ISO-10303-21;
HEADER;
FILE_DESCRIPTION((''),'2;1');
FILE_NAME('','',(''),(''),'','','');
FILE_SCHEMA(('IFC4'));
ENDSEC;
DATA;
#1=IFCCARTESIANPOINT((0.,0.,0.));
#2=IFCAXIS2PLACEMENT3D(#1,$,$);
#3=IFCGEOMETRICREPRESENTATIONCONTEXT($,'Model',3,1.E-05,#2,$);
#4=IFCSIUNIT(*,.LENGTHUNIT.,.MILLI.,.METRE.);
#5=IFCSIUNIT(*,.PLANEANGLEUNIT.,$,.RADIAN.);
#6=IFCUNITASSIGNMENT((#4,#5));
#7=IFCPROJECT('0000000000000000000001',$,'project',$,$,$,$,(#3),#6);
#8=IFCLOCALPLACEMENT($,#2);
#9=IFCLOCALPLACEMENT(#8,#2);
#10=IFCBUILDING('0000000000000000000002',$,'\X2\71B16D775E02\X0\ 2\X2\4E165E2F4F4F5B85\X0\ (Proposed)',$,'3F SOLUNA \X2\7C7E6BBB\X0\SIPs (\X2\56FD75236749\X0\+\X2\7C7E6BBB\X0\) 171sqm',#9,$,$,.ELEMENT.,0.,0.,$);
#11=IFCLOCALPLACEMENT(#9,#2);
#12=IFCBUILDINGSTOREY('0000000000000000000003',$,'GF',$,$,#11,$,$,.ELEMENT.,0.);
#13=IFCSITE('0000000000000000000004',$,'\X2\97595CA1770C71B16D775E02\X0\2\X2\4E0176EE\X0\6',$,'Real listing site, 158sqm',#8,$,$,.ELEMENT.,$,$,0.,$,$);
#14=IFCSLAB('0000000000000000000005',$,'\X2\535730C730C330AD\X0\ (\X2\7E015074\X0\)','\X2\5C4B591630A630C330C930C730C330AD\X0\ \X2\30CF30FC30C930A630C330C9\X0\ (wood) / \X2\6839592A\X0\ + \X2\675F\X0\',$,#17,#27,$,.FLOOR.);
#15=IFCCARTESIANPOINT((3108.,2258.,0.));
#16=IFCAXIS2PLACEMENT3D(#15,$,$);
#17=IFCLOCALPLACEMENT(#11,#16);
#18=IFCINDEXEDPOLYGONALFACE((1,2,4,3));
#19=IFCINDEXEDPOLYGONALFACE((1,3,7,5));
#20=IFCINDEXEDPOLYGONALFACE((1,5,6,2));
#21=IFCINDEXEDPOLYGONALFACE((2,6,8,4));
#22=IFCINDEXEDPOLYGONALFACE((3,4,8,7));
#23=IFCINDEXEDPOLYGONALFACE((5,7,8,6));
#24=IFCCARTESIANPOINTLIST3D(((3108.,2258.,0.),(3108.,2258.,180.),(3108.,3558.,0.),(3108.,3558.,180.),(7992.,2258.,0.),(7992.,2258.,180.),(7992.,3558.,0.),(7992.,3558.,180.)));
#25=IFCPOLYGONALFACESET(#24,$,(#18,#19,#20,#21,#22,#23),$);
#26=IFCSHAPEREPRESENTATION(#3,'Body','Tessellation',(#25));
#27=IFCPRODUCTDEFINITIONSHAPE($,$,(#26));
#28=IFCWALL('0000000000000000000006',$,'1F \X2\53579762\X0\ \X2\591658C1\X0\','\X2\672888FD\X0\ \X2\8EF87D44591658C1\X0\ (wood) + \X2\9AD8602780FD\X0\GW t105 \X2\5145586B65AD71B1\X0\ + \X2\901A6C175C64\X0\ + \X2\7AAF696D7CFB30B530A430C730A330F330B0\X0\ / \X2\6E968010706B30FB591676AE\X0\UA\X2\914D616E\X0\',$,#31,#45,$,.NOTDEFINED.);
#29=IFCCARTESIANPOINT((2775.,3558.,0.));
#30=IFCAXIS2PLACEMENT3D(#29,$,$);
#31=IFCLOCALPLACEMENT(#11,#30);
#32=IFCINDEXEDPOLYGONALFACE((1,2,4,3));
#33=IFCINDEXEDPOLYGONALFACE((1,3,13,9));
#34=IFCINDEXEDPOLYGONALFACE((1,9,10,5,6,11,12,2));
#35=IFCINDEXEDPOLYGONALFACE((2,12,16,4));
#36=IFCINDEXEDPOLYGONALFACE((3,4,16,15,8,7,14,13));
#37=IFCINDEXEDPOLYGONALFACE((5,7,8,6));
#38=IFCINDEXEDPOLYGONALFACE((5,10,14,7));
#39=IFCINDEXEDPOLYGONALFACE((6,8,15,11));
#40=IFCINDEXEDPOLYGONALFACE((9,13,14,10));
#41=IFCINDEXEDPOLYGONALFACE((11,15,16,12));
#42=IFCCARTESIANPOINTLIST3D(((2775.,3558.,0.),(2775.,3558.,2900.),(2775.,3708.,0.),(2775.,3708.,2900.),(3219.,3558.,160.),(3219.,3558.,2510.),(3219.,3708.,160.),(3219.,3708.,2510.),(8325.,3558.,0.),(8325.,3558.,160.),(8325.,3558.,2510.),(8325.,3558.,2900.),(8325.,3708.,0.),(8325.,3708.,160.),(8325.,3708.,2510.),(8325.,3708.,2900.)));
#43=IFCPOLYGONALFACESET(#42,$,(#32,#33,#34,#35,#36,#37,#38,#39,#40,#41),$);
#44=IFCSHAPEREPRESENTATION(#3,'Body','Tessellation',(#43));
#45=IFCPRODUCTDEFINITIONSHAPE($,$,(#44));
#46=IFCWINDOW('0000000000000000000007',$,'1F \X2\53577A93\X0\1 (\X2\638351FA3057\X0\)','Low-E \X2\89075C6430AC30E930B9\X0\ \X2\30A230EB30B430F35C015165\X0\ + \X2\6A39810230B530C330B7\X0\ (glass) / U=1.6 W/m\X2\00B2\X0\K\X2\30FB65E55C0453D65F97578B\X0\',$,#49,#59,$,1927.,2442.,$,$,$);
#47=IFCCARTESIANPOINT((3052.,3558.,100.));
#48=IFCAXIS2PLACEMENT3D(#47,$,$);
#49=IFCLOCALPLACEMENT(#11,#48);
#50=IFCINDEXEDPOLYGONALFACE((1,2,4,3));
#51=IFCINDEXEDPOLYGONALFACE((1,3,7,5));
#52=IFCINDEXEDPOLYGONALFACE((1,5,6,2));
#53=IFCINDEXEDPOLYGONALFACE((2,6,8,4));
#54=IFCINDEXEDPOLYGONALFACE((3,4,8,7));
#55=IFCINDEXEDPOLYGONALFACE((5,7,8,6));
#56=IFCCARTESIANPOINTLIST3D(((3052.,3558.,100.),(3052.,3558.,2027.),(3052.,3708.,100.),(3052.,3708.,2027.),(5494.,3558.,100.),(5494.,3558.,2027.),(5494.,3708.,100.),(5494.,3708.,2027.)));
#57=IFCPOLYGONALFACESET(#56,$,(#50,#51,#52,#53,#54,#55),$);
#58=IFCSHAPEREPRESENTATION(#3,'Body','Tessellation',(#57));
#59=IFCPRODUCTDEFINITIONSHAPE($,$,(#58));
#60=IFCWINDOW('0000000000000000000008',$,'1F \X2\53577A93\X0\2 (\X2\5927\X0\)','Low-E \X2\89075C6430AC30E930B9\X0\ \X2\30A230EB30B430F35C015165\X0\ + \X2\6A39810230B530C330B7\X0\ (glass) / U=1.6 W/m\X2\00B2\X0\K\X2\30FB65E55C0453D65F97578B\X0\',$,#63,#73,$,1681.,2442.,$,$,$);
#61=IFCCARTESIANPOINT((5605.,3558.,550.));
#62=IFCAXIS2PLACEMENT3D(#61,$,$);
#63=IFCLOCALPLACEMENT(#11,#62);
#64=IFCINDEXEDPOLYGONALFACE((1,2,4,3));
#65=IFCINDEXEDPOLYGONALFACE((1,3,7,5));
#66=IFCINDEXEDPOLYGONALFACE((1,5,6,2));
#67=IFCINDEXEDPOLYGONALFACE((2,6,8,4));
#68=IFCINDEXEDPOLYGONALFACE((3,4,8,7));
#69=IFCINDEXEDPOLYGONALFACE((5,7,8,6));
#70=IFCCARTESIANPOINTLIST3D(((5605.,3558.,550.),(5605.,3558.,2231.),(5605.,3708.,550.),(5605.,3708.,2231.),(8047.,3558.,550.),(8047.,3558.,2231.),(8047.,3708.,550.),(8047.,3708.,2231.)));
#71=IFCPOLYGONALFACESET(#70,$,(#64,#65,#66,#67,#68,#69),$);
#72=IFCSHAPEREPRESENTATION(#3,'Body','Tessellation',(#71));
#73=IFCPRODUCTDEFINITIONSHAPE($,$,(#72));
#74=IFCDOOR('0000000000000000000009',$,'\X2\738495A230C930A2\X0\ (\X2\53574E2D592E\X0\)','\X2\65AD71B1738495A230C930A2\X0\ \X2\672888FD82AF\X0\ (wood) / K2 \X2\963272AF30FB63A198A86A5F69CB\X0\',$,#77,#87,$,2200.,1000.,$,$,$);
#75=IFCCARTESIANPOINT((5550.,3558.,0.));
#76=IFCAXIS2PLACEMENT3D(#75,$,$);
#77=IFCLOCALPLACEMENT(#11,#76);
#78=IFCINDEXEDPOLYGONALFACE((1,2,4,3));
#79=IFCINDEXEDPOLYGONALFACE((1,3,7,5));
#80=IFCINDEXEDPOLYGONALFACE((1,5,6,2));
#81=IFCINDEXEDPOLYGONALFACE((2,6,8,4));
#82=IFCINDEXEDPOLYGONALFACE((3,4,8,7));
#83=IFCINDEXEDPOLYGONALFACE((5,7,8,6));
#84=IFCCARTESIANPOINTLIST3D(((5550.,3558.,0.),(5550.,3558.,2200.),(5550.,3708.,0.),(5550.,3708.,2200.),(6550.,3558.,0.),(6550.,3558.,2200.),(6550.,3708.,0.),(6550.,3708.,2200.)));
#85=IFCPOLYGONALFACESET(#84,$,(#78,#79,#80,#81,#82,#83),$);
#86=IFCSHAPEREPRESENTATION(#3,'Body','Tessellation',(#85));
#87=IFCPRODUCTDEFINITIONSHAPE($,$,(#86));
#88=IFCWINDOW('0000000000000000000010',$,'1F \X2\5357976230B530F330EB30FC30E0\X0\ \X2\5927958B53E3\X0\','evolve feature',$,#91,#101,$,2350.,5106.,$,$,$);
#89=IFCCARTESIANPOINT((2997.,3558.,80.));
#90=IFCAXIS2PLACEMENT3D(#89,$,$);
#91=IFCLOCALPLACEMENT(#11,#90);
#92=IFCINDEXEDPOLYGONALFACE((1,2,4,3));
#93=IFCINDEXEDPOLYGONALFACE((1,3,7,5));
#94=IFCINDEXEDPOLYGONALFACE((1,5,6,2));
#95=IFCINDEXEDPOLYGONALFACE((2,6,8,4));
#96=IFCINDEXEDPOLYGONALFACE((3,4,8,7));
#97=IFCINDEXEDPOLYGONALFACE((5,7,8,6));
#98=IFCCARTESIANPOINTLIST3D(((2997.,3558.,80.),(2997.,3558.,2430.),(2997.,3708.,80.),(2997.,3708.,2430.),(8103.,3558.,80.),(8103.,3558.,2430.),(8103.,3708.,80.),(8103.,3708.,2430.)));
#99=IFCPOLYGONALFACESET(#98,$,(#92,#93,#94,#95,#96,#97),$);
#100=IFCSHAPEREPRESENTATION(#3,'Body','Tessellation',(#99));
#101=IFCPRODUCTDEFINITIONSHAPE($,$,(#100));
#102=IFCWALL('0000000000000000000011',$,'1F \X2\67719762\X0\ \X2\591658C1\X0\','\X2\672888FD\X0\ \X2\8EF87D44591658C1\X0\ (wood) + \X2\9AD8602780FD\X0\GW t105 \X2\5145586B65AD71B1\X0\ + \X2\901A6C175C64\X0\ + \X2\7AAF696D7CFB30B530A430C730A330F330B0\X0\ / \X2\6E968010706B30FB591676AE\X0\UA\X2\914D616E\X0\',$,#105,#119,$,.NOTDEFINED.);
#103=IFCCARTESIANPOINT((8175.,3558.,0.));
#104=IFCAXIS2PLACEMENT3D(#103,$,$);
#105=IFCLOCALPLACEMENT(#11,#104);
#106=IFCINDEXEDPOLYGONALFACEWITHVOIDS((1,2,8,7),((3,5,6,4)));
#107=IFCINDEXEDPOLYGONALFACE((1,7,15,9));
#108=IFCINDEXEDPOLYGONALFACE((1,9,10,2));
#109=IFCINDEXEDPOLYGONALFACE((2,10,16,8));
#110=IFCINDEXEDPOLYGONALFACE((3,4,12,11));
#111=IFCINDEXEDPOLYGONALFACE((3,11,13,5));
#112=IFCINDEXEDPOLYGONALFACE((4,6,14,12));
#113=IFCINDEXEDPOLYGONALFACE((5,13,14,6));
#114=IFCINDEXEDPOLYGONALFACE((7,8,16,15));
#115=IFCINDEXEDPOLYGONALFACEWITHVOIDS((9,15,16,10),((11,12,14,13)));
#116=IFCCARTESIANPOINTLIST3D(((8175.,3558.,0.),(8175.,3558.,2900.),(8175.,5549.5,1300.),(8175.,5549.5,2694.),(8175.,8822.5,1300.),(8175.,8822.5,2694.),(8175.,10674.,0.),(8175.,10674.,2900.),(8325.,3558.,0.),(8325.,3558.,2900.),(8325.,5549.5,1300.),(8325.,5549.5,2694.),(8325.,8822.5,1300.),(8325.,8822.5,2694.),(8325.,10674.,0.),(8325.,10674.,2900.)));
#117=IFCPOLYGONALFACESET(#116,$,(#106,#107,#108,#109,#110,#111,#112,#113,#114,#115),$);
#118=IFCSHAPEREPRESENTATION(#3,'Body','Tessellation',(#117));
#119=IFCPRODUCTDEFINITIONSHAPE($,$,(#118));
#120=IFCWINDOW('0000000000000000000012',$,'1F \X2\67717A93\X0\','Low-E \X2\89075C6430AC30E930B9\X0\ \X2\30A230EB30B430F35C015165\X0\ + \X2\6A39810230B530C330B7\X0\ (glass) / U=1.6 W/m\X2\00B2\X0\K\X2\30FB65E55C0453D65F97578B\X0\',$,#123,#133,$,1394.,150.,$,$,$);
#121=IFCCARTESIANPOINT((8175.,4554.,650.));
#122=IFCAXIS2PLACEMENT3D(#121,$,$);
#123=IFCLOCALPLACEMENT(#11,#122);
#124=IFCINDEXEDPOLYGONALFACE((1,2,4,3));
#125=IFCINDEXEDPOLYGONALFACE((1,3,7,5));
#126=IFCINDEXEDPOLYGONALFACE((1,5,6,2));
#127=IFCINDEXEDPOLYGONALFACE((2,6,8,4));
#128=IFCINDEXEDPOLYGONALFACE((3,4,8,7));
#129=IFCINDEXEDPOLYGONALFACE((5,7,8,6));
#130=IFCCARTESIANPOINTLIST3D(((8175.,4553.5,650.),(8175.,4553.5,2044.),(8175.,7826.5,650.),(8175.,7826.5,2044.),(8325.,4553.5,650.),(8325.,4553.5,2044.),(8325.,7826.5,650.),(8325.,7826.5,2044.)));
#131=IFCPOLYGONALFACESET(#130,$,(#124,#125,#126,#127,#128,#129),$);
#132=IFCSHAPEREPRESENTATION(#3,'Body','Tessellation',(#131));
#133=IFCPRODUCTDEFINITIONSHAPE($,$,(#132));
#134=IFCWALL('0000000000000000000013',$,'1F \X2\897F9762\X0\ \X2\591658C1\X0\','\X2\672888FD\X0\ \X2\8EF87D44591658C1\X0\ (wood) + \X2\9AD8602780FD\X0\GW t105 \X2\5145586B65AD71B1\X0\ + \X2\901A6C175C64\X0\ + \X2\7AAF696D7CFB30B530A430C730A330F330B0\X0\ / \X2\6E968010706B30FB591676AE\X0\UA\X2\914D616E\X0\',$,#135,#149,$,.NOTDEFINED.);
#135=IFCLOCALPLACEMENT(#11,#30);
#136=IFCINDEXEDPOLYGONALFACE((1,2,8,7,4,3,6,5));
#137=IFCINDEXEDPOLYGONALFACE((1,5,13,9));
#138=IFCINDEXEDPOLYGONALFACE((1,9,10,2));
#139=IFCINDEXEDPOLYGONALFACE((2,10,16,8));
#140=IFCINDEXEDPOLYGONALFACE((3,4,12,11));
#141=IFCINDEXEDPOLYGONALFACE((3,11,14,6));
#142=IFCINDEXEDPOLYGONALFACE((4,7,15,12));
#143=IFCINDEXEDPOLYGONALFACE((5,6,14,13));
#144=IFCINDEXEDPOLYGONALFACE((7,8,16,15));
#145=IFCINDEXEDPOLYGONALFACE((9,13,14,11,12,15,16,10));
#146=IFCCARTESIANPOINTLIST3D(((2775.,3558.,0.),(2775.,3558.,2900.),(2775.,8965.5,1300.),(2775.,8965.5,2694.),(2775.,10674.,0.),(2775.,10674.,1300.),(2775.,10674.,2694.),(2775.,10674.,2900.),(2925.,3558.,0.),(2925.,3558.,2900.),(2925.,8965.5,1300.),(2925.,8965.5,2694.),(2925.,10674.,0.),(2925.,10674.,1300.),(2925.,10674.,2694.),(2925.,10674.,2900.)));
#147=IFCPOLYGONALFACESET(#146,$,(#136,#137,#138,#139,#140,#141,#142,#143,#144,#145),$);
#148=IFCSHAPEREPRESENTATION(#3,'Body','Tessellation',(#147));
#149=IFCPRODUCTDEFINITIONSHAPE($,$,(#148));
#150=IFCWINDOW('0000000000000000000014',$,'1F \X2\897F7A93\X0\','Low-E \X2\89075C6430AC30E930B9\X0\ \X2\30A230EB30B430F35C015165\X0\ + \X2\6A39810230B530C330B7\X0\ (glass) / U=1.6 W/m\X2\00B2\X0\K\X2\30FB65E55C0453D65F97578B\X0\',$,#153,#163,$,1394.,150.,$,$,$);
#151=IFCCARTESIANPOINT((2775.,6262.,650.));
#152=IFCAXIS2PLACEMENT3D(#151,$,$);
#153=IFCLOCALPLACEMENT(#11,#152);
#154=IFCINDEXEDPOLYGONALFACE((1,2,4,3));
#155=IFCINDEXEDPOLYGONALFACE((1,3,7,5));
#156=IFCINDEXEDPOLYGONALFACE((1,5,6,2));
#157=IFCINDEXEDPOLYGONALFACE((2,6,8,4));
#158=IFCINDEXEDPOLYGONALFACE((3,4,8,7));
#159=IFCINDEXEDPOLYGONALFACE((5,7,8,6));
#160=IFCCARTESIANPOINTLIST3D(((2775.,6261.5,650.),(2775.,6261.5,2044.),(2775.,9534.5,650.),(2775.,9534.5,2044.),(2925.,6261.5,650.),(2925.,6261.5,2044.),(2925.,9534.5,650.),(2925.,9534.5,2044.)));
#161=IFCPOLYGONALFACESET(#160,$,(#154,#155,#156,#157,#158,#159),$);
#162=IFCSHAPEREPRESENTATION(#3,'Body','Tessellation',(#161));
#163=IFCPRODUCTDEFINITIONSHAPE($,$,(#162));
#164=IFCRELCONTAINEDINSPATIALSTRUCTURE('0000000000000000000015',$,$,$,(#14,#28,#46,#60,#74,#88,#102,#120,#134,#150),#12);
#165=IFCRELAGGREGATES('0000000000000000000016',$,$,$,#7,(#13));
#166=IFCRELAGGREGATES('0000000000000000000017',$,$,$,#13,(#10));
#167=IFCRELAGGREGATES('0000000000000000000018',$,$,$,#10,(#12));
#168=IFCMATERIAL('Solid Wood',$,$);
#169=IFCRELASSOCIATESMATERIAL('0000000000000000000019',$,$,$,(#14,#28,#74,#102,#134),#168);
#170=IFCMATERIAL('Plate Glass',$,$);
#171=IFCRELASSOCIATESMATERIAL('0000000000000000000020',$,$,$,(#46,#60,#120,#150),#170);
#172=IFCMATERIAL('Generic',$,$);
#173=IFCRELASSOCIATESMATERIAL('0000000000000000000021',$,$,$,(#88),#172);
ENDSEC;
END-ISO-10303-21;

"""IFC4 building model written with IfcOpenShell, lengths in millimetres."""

from ifc_helpers import new_model, si_unit, frame, frame_2d, origin, place, context, project, spatial, rectangle, extrude, material, element, fill, save


model = new_model("IFC4")

# Units and contexts
model_context = context("Model", 3, precision=1e-05, world=origin())
ifc_project = project(units=[si_unit("LENGTHUNIT", "METRE", prefix="MILLI"), si_unit("PLANEANGLEUNIT", "RADIAN")], contexts=[model_context])

# Site, building, storey
site_placement = place(None, origin())
site = spatial("IfcSite", under=ifc_project, at=site_placement, Name="静岡県熱海市2丁目6", ObjectType="Real listing site, 158sqm", CompositionType="ELEMENT", RefElevation=0.0)
building_placement = place(site_placement, origin())
building = spatial("IfcBuilding", under=site, at=building_placement, Name="熱海市 2世帯住宅 (Proposed)", ObjectType="3F SOLUNA 籾殻SIPs (国産杉+籾殻) 171sqm", CompositionType="ELEMENT", ElevationOfRefHeight=0.0, ElevationOfTerrain=0.0)
storey_placement = place(building_placement, origin())
storey = spatial("IfcBuildingStorey", under=building, at=storey_placement, Name="GF", CompositionType="ELEMENT", Elevation=0.0)

# Slab
ifc_material_1 = material(Name="Solid Wood")
slab_1_placement = place(storey_placement, frame((3108.0, 2258.0, 0.0)))
element("IfcSlab", 1, at=slab_1_placement, inside=storey, material=ifc_material_1, Name="南デッキ (縁側)", Description="屋外ウッドデッキ ハードウッド (wood) / 根太 + 束", PredefinedType="FLOOR", context=model_context, shape_type="SweptSolid", body=[
    extrude(rectangle(XDim=4884.0, YDim=1300.0, at=frame_2d((2442.0, 650.0))), frame((3108.0, 2258.0, 0.0)), (0.0, 0.0, 1.0), 180.0),
])

# Wall, openings, windows, door
wall_1_placement = place(storey_placement, frame((2775.0, 3558.0, 0.0)))
wall_1 = element("IfcWall", 2, at=wall_1_placement, inside=storey, material=ifc_material_1, Name="1F 南面 外壁", Description="木製 軸組外壁 (wood) + 高性能GW t105 充填断熱 + 通気層 + 窯業系サイディング / 準耐火・外皮UA配慮", PredefinedType="NOTDEFINED", context=model_context, shape_type="SweptSolid", body=[
    extrude(rectangle(XDim=5550.0, YDim=150.0, at=frame_2d((2775.0, 75.0))), frame((2775.0, 3558.0, 0.0)), (0.0, 0.0, 1.0), 2900.0),
])
opening_1_placement = place(storey_placement, frame((3052.0, 3558.0, 100.0)))
opening_1 = element("IfcOpeningElement", 3, at=opening_1_placement, cuts=wall_1, PredefinedType="NOTDEFINED", context=model_context, shape_type="SweptSolid", body=[
    extrude(rectangle(XDim=2442.0, YDim=150.0, at=frame_2d((1221.0, 75.0))), frame((3052.0, 3558.0, 100.0)), (0.0, 0.0, 1.0), 1927.0),
])
opening_2_placement = place(storey_placement, frame((5605.0, 3558.0, 550.0)))
opening_2 = element("IfcOpeningElement", 4, at=opening_2_placement, cuts=wall_1, PredefinedType="NOTDEFINED", context=model_context, shape_type="SweptSolid", body=[
    extrude(rectangle(XDim=2442.0, YDim=150.0, at=frame_2d((1221.0, 75.0))), frame((5605.0, 3558.0, 550.0)), (0.0, 0.0, 1.0), 1681.0),
])
opening_3_placement = place(storey_placement, frame((5550.0, 3558.0, 0.0)))
opening_3 = element("IfcOpeningElement", 5, at=opening_3_placement, cuts=wall_1, PredefinedType="NOTDEFINED", context=model_context, shape_type="SweptSolid", body=[
    extrude(rectangle(XDim=1000.0, YDim=150.0, at=frame_2d((500.0, 75.0))), frame((5550.0, 3558.0, 0.0)), (0.0, 0.0, 1.0), 2200.0),
])
opening_4_placement = place(storey_placement, frame((2997.0, 3558.0, 80.0)))
opening_4 = element("IfcOpeningElement", 6, at=opening_4_placement, cuts=wall_1, PredefinedType="NOTDEFINED", context=model_context, shape_type="SweptSolid", body=[
    extrude(rectangle(XDim=5106.0, YDim=150.0, at=frame_2d((2553.0, 75.0))), frame((2997.0, 3558.0, 80.0)), (0.0, 0.0, 1.0), 2350.0),
])
ifc_material_2 = material(Name="Plate Glass")
window_1_placement = place(storey_placement, frame((3052.0, 3558.0, 100.0)))
window_1 = element("IfcWindow", 7, at=window_1_placement, inside=storey, material=ifc_material_2, Name="1F 南窓1 (掃出し)", Description="Low-E 複層ガラス アルゴン封入 + 樹脂サッシ (glass) / U=1.6 W/m²K・日射取得型", OverallHeight=1927.0, OverallWidth=2442.0, context=model_context, shape_type="SweptSolid", body=[
    extrude(rectangle(XDim=2442.0, YDim=150.0, at=frame_2d((1221.0, 75.0))), frame((3052.0, 3558.0, 100.0)), (0.0, 0.0, 1.0), 1927.0),
])
fill(opening_1, window_1)
window_2_placement = place(storey_placement, frame((5605.0, 3558.0, 550.0)))
window_2 = element("IfcWindow", 8, at=window_2_placement, inside=storey, material=ifc_material_2, Name="1F 南窓2 (大)", Description="Low-E 複層ガラス アルゴン封入 + 樹脂サッシ (glass) / U=1.6 W/m²K・日射取得型", OverallHeight=1681.0, OverallWidth=2442.0, context=model_context, shape_type="SweptSolid", body=[
    extrude(rectangle(XDim=2442.0, YDim=150.0, at=frame_2d((1221.0, 75.0))), frame((5605.0, 3558.0, 550.0)), (0.0, 0.0, 1.0), 1681.0),
])
fill(opening_2, window_2)
door_placement = place(storey_placement, frame((5550.0, 3558.0, 0.0)))
door = element("IfcDoor", 9, at=door_placement, inside=storey, material=ifc_material_1, Name="玄関ドア (南中央)", Description="断熱玄関ドア 木製芯 (wood) / K2 防犯・採風機構", OverallHeight=2200.0, OverallWidth=1000.0, context=model_context, shape_type="SweptSolid", body=[
    extrude(rectangle(XDim=1000.0, YDim=150.0, at=frame_2d((500.0, 75.0))), frame((5550.0, 3558.0, 0.0)), (0.0, 0.0, 1.0), 2200.0),
])
fill(opening_3, door)
ifc_material_3 = material(Name="Generic")
window_3_placement = place(storey_placement, frame((2997.0, 3558.0, 80.0)))
window_3 = element("IfcWindow", 10, at=window_3_placement, inside=storey, material=ifc_material_3, Name="1F 南面サンルーム 大開口", Description="evolve feature", OverallHeight=2350.0, OverallWidth=5106.0, context=model_context, shape_type="SweptSolid", body=[
    extrude(rectangle(XDim=5106.0, YDim=150.0, at=frame_2d((2553.0, 75.0))), frame((2997.0, 3558.0, 80.0)), (0.0, 0.0, 1.0), 2350.0),
])
fill(opening_4, window_3)

# Walls, openings, windows
wall_2_placement = place(storey_placement, frame((8175.0, 3558.0, 0.0)))
wall_2 = element("IfcWall", 11, at=wall_2_placement, inside=storey, material=ifc_material_1, Name="1F 東面 外壁", Description="木製 軸組外壁 (wood) + 高性能GW t105 充填断熱 + 通気層 + 窯業系サイディング / 準耐火・外皮UA配慮", PredefinedType="NOTDEFINED", context=model_context, shape_type="SweptSolid", body=[
    extrude(rectangle(XDim=150.0, YDim=7116.0, at=frame_2d((75.0, 3558.0))), frame((8175.0, 3558.0, 0.0)), (0.0, 0.0, 1.0), 2900.0),
])
opening_5_placement = place(storey_placement, frame((8175.0, 4554.0, 650.0)))
opening_5 = element("IfcOpeningElement", 12, at=opening_5_placement, cuts=wall_2, PredefinedType="NOTDEFINED", context=model_context, shape_type="SweptSolid", body=[
    extrude(rectangle(XDim=150.0, YDim=3273.0, at=frame_2d((75.0, 1636.0))), frame((8175.0, 4554.0, 650.0)), (0.0, 0.0, 1.0), 1394.0),
])
window_4_placement = place(storey_placement, frame((8175.0, 4554.0, 650.0)))
window_4 = element("IfcWindow", 13, at=window_4_placement, inside=storey, material=ifc_material_2, Name="1F 東窓", Description="Low-E 複層ガラス アルゴン封入 + 樹脂サッシ (glass) / U=1.6 W/m²K・日射取得型", OverallHeight=1394.0, OverallWidth=150.0, context=model_context, shape_type="SweptSolid", body=[
    extrude(rectangle(XDim=150.0, YDim=3273.0, at=frame_2d((75.0, 1636.0))), frame((8175.0, 4554.0, 650.0)), (0.0, 0.0, 1.0), 1394.0),
])
fill(opening_5, window_4)
wall_3_placement = place(storey_placement, frame((2775.0, 3558.0, 0.0)))
wall_3 = element("IfcWall", 14, at=wall_3_placement, inside=storey, material=ifc_material_1, Name="1F 西面 外壁", Description="木製 軸組外壁 (wood) + 高性能GW t105 充填断熱 + 通気層 + 窯業系サイディング / 準耐火・外皮UA配慮", PredefinedType="NOTDEFINED", context=model_context, shape_type="SweptSolid", body=[
    extrude(rectangle(XDim=150.0, YDim=7116.0, at=frame_2d((75.0, 3558.0))), frame((2775.0, 3558.0, 0.0)), (0.0, 0.0, 1.0), 2900.0),
])
opening_6_placement = place(storey_placement, frame((2775.0, 6262.0, 650.0)))
opening_6 = element("IfcOpeningElement", 15, at=opening_6_placement, cuts=wall_3, PredefinedType="NOTDEFINED", context=model_context, shape_type="SweptSolid", body=[
    extrude(rectangle(XDim=150.0, YDim=3273.0, at=frame_2d((75.0, 1636.0))), frame((2775.0, 6262.0, 650.0)), (0.0, 0.0, 1.0), 1394.0),
])
window_5_placement = place(storey_placement, frame((2775.0, 6262.0, 650.0)))
window_5 = element("IfcWindow", 16, at=window_5_placement, inside=storey, material=ifc_material_2, Name="1F 西窓", Description="Low-E 複層ガラス アルゴン封入 + 樹脂サッシ (glass) / U=1.6 W/m²K・日射取得型", OverallHeight=1394.0, OverallWidth=150.0, context=model_context, shape_type="SweptSolid", body=[
    extrude(rectangle(XDim=150.0, YDim=3273.0, at=frame_2d((75.0, 1636.0))), frame((2775.0, 6262.0, 650.0)), (0.0, 0.0, 1.0), 1394.0),
])
fill(opening_6, window_5)

save(model, "model.ifc")
